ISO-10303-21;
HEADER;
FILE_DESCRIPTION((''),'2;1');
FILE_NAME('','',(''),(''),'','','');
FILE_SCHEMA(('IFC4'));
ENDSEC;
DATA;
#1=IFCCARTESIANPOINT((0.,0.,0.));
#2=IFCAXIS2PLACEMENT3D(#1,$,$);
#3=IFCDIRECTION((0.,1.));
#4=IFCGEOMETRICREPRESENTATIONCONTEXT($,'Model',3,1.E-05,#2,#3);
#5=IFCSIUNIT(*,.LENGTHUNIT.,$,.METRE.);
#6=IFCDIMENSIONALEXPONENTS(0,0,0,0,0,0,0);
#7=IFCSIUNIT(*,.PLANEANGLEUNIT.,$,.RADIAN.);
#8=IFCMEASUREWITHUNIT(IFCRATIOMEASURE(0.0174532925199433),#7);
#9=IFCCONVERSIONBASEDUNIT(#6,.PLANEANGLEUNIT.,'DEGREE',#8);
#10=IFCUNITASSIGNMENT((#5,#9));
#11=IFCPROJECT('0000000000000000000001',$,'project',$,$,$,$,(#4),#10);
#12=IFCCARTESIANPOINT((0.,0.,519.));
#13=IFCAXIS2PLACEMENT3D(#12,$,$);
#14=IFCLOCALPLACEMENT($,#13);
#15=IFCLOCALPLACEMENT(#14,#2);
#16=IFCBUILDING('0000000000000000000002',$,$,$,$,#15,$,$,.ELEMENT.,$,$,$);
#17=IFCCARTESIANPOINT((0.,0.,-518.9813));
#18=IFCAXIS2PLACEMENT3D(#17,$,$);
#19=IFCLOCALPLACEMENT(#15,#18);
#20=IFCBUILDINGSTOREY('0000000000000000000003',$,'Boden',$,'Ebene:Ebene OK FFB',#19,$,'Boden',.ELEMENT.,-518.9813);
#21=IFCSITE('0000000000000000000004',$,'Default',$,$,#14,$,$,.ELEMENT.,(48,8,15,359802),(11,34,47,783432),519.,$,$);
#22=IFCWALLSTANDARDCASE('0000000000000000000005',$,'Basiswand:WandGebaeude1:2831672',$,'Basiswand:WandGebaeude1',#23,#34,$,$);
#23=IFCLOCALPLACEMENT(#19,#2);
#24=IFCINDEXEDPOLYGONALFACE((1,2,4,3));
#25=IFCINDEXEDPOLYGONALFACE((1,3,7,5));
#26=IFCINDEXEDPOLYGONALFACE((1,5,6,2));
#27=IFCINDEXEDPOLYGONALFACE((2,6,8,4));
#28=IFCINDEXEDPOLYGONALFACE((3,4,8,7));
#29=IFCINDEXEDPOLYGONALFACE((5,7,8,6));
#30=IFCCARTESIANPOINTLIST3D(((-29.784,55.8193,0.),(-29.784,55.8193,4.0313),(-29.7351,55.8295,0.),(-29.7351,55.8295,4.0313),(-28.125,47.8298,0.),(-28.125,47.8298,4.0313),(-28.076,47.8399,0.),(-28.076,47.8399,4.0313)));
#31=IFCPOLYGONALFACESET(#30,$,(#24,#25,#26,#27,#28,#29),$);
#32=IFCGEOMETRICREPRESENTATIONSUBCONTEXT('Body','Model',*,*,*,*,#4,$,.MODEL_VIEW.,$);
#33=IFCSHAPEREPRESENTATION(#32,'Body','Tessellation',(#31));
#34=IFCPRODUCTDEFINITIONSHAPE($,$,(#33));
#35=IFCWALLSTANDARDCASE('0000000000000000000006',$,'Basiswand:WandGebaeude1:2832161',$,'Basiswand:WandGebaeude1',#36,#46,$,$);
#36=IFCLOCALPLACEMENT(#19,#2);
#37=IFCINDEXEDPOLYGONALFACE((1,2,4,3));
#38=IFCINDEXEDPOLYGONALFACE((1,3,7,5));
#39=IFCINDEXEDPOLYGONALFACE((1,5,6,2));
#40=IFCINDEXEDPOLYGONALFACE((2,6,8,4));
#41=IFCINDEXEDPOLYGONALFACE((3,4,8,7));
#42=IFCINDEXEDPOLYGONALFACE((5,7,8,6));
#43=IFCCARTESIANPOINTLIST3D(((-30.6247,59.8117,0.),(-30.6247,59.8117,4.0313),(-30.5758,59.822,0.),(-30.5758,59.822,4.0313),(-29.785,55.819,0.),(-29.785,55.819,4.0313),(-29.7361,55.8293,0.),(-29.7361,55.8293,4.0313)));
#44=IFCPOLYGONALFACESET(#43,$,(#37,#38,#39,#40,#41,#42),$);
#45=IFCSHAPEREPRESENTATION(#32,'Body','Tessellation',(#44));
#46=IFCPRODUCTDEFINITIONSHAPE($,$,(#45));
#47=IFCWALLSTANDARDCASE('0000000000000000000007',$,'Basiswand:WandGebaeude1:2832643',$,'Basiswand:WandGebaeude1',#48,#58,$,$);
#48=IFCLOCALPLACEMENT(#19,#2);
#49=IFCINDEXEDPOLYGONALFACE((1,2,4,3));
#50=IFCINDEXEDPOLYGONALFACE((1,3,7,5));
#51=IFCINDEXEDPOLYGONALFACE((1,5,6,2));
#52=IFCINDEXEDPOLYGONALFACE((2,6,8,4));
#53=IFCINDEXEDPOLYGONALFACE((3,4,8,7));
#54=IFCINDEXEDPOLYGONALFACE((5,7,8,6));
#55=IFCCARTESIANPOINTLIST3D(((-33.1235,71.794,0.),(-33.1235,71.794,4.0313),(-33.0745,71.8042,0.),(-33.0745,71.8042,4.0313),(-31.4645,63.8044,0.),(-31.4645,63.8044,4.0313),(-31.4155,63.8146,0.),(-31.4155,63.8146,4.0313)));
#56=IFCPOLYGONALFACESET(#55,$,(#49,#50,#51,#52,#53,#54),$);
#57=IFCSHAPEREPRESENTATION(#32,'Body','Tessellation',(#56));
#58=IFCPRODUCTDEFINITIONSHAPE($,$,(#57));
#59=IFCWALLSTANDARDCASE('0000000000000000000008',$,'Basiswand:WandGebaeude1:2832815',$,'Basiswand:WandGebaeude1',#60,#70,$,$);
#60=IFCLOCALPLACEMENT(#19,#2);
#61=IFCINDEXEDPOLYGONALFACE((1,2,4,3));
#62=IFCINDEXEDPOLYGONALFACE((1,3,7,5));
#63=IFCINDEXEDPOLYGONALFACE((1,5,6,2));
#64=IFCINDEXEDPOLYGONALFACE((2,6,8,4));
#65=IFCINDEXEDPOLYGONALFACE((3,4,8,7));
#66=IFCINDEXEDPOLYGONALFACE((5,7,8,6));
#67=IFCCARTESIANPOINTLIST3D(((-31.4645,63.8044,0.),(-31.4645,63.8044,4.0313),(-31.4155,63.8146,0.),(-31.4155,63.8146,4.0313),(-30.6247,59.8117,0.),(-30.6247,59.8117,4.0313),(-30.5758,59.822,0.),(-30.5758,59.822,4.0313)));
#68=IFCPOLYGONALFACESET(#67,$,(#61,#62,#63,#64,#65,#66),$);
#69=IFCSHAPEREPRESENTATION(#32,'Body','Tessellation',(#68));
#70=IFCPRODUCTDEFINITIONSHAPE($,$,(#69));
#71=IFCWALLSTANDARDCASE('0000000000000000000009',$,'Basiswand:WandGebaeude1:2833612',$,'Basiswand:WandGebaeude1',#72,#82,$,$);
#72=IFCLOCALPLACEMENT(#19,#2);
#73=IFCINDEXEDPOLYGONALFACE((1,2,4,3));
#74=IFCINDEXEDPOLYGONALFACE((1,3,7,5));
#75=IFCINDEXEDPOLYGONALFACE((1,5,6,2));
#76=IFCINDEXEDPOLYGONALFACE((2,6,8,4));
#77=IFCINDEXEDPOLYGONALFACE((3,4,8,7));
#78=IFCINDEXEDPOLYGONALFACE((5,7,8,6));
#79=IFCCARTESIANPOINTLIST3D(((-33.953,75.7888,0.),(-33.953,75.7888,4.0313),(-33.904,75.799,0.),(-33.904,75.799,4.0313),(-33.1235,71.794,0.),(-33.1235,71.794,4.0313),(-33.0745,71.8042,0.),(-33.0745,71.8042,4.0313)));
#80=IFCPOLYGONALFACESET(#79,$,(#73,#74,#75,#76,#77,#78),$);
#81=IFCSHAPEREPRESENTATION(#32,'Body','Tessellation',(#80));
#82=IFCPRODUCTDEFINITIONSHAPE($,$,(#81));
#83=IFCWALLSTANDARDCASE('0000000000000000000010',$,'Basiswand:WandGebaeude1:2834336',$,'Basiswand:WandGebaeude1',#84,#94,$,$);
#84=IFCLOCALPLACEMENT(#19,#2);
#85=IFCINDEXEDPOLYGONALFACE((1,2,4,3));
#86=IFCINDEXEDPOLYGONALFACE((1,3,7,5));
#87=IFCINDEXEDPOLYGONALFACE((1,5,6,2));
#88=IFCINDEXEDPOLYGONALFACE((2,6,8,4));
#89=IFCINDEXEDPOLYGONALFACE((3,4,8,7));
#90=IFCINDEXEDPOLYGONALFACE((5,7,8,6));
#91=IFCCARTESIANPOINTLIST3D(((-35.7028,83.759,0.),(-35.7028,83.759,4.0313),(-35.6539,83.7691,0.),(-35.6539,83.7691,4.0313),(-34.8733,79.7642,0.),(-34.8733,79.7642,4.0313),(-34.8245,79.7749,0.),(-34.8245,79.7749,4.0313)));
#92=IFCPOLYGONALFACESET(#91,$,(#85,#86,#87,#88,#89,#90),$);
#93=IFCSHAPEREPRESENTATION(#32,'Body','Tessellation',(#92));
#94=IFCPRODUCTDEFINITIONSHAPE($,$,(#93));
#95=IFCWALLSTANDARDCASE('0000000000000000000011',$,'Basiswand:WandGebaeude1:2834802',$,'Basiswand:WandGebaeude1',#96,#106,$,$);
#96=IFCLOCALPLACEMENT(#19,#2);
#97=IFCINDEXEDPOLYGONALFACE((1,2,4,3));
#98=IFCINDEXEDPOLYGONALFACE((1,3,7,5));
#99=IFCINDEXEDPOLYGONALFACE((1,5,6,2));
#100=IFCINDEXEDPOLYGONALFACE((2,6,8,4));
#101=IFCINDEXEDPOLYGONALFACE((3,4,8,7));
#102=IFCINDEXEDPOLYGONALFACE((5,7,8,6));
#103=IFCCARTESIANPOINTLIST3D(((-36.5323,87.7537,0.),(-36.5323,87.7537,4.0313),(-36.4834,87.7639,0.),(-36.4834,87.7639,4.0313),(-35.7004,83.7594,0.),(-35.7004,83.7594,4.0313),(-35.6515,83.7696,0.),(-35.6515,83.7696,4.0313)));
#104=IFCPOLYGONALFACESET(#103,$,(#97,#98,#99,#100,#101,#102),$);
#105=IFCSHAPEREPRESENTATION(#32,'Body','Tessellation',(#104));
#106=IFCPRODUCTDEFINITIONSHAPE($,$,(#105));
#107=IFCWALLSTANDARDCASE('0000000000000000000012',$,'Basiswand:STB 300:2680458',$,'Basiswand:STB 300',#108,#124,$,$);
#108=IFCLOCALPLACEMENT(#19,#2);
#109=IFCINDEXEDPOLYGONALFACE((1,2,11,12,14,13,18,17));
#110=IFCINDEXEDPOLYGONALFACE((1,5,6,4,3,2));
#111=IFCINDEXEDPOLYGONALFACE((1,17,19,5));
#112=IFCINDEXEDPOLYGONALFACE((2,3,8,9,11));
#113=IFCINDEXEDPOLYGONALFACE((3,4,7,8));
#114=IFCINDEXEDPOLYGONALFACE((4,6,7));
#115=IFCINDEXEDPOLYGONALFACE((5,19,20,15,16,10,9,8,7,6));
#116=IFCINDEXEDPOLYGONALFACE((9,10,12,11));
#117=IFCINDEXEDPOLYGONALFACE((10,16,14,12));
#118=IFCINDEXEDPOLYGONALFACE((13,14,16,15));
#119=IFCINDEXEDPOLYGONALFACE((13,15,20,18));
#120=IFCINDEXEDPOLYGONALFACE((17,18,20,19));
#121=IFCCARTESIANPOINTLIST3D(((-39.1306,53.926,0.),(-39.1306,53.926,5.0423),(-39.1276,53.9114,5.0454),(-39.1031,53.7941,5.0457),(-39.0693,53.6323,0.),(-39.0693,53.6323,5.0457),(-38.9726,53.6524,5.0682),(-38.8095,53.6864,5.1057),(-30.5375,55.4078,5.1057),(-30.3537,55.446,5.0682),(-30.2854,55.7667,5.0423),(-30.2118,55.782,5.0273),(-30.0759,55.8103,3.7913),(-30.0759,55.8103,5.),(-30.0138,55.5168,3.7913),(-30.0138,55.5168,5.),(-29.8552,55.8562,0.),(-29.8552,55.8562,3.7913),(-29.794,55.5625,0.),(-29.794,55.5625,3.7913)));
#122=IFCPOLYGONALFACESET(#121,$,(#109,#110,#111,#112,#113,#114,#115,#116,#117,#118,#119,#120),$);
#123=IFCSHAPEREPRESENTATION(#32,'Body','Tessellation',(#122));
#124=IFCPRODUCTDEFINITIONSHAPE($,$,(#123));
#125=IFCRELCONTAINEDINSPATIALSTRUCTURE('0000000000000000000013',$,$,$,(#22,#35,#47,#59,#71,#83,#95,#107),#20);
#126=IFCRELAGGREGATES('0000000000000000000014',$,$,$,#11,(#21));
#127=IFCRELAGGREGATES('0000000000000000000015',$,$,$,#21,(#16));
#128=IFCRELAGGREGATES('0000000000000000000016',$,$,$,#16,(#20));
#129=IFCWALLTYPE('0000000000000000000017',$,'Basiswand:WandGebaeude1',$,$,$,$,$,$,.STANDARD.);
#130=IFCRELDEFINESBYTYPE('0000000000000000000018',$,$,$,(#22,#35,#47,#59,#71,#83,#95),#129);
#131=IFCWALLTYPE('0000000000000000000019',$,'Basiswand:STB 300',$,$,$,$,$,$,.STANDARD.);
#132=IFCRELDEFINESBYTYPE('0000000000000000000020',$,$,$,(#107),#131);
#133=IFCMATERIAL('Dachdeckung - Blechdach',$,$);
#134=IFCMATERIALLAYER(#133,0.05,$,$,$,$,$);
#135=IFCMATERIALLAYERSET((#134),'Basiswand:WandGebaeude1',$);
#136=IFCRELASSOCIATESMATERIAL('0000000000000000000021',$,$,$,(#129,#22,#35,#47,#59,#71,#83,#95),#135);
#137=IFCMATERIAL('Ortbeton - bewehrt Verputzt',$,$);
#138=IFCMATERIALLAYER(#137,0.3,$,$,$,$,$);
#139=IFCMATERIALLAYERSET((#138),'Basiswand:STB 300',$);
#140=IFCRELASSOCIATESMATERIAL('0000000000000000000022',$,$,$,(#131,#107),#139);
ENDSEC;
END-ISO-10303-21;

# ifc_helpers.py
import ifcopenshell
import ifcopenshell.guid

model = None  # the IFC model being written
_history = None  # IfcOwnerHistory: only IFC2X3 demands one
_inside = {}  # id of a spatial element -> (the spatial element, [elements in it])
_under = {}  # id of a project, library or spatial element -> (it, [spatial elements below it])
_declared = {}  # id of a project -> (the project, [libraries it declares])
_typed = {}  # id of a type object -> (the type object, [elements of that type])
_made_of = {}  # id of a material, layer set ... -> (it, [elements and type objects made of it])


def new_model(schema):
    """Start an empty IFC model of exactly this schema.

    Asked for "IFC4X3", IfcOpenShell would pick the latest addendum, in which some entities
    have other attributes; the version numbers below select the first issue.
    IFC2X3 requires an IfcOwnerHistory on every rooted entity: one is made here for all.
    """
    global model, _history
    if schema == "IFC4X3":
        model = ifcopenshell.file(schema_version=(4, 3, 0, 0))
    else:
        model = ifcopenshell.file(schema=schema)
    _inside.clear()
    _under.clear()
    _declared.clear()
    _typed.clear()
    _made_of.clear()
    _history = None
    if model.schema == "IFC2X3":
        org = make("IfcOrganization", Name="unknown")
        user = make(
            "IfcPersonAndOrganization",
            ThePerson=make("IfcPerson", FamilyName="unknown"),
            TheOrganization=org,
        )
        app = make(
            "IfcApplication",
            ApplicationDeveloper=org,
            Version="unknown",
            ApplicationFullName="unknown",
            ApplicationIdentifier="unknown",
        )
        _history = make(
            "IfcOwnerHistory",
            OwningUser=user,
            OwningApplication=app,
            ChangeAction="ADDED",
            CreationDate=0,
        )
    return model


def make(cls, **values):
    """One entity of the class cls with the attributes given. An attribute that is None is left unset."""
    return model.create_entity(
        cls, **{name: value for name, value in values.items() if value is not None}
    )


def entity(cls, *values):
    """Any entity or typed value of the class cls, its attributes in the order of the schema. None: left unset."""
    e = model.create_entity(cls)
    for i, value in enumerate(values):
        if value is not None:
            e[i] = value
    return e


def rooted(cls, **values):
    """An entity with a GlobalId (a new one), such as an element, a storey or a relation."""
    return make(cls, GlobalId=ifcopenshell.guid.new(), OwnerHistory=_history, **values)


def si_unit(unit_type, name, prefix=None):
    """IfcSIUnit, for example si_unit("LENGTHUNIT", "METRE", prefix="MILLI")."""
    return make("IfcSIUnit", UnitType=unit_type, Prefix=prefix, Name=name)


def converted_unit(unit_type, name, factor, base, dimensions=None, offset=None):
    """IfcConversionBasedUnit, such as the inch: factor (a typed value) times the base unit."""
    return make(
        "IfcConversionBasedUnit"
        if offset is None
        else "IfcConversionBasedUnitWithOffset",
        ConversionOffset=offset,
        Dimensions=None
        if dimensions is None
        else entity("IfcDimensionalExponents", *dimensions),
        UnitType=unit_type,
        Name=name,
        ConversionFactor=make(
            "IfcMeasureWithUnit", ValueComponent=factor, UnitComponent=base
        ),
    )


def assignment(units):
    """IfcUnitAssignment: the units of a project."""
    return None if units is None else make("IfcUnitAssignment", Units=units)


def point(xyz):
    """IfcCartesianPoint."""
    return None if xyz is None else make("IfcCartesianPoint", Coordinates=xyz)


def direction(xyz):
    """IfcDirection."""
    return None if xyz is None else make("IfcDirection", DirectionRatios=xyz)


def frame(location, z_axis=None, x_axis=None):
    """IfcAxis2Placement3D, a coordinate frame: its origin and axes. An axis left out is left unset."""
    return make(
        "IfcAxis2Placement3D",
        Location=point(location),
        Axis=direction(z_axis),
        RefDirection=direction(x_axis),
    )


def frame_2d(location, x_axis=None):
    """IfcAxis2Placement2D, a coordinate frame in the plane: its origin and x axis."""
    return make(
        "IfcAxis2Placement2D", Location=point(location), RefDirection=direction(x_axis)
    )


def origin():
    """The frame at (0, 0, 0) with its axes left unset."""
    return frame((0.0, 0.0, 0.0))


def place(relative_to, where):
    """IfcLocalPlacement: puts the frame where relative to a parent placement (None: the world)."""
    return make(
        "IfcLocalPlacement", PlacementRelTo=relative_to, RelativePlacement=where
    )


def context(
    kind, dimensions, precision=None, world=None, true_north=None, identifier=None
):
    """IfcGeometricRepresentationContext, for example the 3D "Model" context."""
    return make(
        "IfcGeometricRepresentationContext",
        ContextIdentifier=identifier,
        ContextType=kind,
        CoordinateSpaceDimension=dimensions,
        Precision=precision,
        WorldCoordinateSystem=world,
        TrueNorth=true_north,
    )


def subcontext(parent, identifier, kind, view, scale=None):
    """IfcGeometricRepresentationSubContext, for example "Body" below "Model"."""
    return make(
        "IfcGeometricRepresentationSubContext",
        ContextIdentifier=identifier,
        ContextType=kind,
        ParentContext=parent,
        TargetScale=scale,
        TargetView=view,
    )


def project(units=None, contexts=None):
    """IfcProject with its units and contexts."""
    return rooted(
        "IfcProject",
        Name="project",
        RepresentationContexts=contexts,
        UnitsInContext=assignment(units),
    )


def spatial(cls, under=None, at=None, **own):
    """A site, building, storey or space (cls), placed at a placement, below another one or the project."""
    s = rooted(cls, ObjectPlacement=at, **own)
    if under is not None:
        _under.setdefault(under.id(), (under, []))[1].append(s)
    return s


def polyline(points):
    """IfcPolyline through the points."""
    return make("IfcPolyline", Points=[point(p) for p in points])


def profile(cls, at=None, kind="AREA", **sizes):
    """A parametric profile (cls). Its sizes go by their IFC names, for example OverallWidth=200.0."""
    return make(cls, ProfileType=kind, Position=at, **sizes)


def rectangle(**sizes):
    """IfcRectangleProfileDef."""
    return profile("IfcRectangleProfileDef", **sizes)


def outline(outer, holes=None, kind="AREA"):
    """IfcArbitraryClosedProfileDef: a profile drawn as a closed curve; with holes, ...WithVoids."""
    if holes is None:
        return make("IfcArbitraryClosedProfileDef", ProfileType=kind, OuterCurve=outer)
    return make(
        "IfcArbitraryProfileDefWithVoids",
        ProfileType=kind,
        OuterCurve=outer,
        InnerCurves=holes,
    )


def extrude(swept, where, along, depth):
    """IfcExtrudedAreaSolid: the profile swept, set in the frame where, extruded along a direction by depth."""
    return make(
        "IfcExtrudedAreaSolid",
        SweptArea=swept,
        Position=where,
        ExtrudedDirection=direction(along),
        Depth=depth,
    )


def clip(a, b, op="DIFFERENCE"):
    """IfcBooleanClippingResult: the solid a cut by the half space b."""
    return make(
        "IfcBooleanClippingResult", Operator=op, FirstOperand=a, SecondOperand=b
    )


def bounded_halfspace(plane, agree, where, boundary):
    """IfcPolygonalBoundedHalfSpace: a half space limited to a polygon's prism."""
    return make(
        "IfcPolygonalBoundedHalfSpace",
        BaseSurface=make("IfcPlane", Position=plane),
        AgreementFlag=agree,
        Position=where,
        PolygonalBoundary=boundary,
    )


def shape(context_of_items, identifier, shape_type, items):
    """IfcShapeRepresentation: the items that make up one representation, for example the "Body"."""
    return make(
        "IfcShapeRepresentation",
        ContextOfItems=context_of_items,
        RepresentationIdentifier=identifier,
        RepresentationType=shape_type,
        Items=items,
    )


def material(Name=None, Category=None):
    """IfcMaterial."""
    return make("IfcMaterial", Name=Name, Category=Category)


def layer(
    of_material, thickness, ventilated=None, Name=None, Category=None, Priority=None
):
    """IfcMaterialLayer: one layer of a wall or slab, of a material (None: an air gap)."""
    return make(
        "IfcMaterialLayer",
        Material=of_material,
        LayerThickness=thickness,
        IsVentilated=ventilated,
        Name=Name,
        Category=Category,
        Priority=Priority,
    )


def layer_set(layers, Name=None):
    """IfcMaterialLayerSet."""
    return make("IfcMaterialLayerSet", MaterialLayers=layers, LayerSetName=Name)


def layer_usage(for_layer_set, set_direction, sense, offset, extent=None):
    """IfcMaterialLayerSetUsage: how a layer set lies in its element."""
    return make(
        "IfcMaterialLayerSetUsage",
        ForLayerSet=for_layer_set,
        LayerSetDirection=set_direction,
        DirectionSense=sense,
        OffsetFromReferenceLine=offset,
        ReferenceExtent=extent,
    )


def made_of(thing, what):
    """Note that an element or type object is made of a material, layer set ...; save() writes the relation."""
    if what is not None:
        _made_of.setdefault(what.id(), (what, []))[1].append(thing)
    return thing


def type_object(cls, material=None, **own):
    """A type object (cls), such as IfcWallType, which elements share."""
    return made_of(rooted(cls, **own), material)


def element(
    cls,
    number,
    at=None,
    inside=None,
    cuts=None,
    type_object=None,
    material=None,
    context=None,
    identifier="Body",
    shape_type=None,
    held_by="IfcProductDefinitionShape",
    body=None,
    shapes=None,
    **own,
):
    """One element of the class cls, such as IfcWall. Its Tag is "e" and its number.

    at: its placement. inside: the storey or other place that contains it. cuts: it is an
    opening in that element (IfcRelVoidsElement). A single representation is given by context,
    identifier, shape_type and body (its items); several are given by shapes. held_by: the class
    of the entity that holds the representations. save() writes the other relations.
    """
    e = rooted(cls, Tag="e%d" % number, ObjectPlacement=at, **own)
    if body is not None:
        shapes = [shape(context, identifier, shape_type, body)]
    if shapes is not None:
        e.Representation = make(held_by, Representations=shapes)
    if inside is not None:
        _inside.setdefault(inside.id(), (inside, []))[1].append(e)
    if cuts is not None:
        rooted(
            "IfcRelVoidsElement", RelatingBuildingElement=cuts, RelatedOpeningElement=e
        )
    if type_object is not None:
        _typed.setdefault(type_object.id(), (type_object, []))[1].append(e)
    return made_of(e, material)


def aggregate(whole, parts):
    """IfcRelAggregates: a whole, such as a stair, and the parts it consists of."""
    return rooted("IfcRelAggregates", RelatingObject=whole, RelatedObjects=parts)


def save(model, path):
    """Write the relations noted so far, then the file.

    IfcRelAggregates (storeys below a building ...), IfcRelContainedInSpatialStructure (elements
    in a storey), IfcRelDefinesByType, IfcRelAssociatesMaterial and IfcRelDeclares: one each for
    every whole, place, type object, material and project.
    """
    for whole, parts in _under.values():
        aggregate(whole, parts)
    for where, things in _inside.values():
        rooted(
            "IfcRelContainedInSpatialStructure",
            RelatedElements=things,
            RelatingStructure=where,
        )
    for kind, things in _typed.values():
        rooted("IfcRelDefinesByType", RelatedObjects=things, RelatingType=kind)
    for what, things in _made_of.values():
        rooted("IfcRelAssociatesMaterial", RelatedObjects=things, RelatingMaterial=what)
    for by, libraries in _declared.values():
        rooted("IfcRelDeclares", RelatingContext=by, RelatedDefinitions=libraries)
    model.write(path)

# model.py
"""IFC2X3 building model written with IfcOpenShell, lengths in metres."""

from ifc_helpers import new_model, entity, si_unit, converted_unit, direction, frame, frame_2d, origin, place, context, subcontext, project, spatial, polyline, rectangle, outline, extrude, clip, bounded_halfspace, material, layer, layer_set, layer_usage, type_object, element, save


model = new_model("IFC2X3")

# Units and contexts
model_context = context("Model", 3, precision=1e-05, world=origin(), true_north=direction((0.0, 1.0)))
body_context = subcontext(model_context, "Body", "Model", "MODEL_VIEW")
ifc_project = project(units=[si_unit("LENGTHUNIT", "METRE"), converted_unit("PLANEANGLEUNIT", "DEGREE", entity("IfcRatioMeasure", 0.0174532925199433), si_unit("PLANEANGLEUNIT", "RADIAN"), dimensions=[0, 0, 0, 0, 0, 0, 0])], contexts=[model_context])

# Site, building, storey
site_placement = place(None, frame((0.0, 0.0, 519.0)))
site = spatial("IfcSite", under=ifc_project, at=site_placement, Name="Default", CompositionType="ELEMENT", RefLatitude=(48, 8, 15, 359802), RefLongitude=(11, 34, 47, 783432), RefElevation=519.0)
building_placement = place(site_placement, origin())
building = spatial("IfcBuilding", under=site, at=building_placement, CompositionType="ELEMENT")
storey_placement = place(building_placement, frame((0.0, 0.0, -518.9813)))
storey = spatial("IfcBuildingStorey", under=building, at=storey_placement, Name="Boden", ObjectType="Ebene:Ebene OK FFB", LongName="Boden", CompositionType="ELEMENT", Elevation=-518.9813)

# Walls
ifc_material_1 = material(Name="Dachdeckung - Blechdach")
ifc_layer_1 = layer(ifc_material_1, 0.05)
ifc_layer_set_1 = layer_set([ifc_layer_1], Name="Basiswand:WandGebaeude1")
wall_type_1 = type_object("IfcWallType", Name="Basiswand:WandGebaeude1", PredefinedType="STANDARD", material=ifc_layer_set_1)
ifc_layer_usage_1 = layer_usage(ifc_layer_set_1, "AXIS2", "NEGATIVE", 0.025)
wall_1_placement = place(storey_placement, frame((-28.1005, 47.8349, 0.0), z_axis=(0.0, 0.0, 1.0), x_axis=(-0.203311, 0.979114, 0.0)))
element("IfcWallStandardCase", 1, at=wall_1_placement, inside=storey, type_object=wall_type_1, material=ifc_layer_usage_1, Name="Basiswand:WandGebaeude1:2831672", ObjectType="Basiswand:WandGebaeude1", context=body_context, shape_type="SweptSolid", body=[
    extrude(rectangle(XDim=8.16, YDim=0.05, at=frame_2d((4.08, 0.0), x_axis=(-1.0, 0.0))), origin(), (0.0, 0.0, 1.0), 4.0313),
])
ifc_layer_usage_2 = layer_usage(ifc_layer_set_1, "AXIS2", "NEGATIVE", 0.025)
wall_2_placement = place(storey_placement, frame((-29.7606, 55.8241, 0.0), z_axis=(0.0, 0.0, 1.0), x_axis=(-0.20581, 0.978592, 0.0)))
element("IfcWallStandardCase", 2, at=wall_2_placement, inside=storey, type_object=wall_type_1, material=ifc_layer_usage_2, Name="Basiswand:WandGebaeude1:2832161", ObjectType="Basiswand:WandGebaeude1", context=body_context, shape_type="SweptSolid", body=[
    extrude(rectangle(XDim=4.08, YDim=0.05, at=frame_2d((2.04, 0.0), x_axis=(-1.0, 0.0))), origin(), (0.0, 0.0, 1.0), 4.0313),
])
ifc_layer_usage_3 = layer_usage(ifc_layer_set_1, "AXIS2", "NEGATIVE", 0.025)
wall_3_placement = place(storey_placement, frame((-31.44, 63.8095, 0.0), z_axis=(0.0, 0.0, 1.0), x_axis=(-0.203311, 0.979114, 0.0)))
element("IfcWallStandardCase", 3, at=wall_3_placement, inside=storey, type_object=wall_type_1, material=ifc_layer_usage_3, Name="Basiswand:WandGebaeude1:2832643", ObjectType="Basiswand:WandGebaeude1", context=body_context, shape_type="SweptSolid", body=[
    extrude(outline(polyline([(8.1601, -0.025), (8.1601, 0.025), (0.0, 0.025), (0.0001, -0.025), (8.1601, -0.025)])), origin(), (0.0, 0.0, 1.0), 4.0313),
])
ifc_layer_usage_4 = layer_usage(ifc_layer_set_1, "AXIS2", "NEGATIVE", 0.025)
wall_4_placement = place(storey_placement, frame((-30.6003, 59.8168, 0.0), z_axis=(0.0, 0.0, 1.0), x_axis=(-0.20581, 0.978592, 0.0)))
element("IfcWallStandardCase", 4, at=wall_4_placement, inside=storey, type_object=wall_type_1, material=ifc_layer_usage_4, Name="Basiswand:WandGebaeude1:2832815", ObjectType="Basiswand:WandGebaeude1", context=body_context, shape_type="SweptSolid", body=[
    extrude(outline(polyline([(4.08, -0.025), (4.0801, 0.025), (0.0, 0.025), (0.0, -0.025), (4.08, -0.025)])), origin(), (0.0, 0.0, 1.0), 4.0313),
])
ifc_layer_usage_5 = layer_usage(ifc_layer_set_1, "AXIS2", "NEGATIVE", 0.025)
wall_5_placement = place(storey_placement, frame((-33.099, 71.7991, 0.0), z_axis=(0.0, 0.0, 1.0), x_axis=(-0.203311, 0.979114, 0.0)))
element("IfcWallStandardCase", 5, at=wall_5_placement, inside=storey, type_object=wall_type_1, material=ifc_layer_usage_5, Name="Basiswand:WandGebaeude1:2833612", ObjectType="Basiswand:WandGebaeude1", context=body_context, shape_type="SweptSolid", body=[
    extrude(rectangle(XDim=4.08, YDim=0.05, at=frame_2d((2.04, 0.0), x_axis=(-1.0, 0.0))), origin(), (0.0, 0.0, 1.0), 4.0313),
])
ifc_layer_usage_6 = layer_usage(ifc_layer_set_1, "AXIS2", "NEGATIVE", 0.025)
wall_6_placement = place(storey_placement, frame((-34.8488, 79.7693, 0.0), z_axis=(0.0, 0.0, 1.0), x_axis=(-0.203311, 0.979114, 0.0)))
element("IfcWallStandardCase", 6, at=wall_6_placement, inside=storey, type_object=wall_type_1, material=ifc_layer_usage_6, Name="Basiswand:WandGebaeude1:2834336", ObjectType="Basiswand:WandGebaeude1", context=body_context, shape_type="SweptSolid", body=[
    extrude(outline(polyline([(4.08, -0.025), (4.08, 0.025), (0.0, 0.025), (0.0006, -0.025), (4.08, -0.025)])), origin(), (0.0, 0.0, 1.0), 4.0313),
])
ifc_layer_usage_7 = layer_usage(ifc_layer_set_1, "AXIS2", "NEGATIVE", 0.025)
wall_7_placement = place(storey_placement, frame((-35.6759, 83.7645, 0.0), z_axis=(0.0, 0.0, 1.0), x_axis=(-0.203899, 0.978992, 0.0)))
element("IfcWallStandardCase", 7, at=wall_7_placement, inside=storey, type_object=wall_type_1, material=ifc_layer_usage_7, Name="Basiswand:WandGebaeude1:2834802", ObjectType="Basiswand:WandGebaeude1", context=body_context, shape_type="SweptSolid", body=[
    extrude(rectangle(XDim=4.08, YDim=0.05, at=frame_2d((2.04, 0.0), x_axis=(-1.0, 0.0))), origin(), (0.0, 0.0, 1.0), 4.0313),
])
ifc_material_2 = material(Name="Ortbeton - bewehrt Verputzt")
ifc_layer_2 = layer(ifc_material_2, 0.3)
ifc_layer_set_2 = layer_set([ifc_layer_2], Name="Basiswand:STB 300")
ifc_layer_usage_8 = layer_usage(ifc_layer_set_2, "AXIS2", "NEGATIVE", 0.15)
wall_type_2 = type_object("IfcWallType", Name="Basiswand:STB 300", PredefinedType="STANDARD", material=ifc_layer_set_2)
wall_8_placement = place(storey_placement, frame((-39.1001, 53.7791, 0.0), z_axis=(0.0, 0.0, 1.0), x_axis=(0.979026, 0.203735, 0.0)))
element("IfcWallStandardCase", 8, at=wall_8_placement, inside=storey, type_object=wall_type_2, material=ifc_layer_usage_8, Name="Basiswand:STB 300:2680458", ObjectType="Basiswand:STB 300", context=body_context, shape_type="Clipping", body=[
    clip(clip(clip(clip(clip(clip(extrude(outline(polyline([(9.4742, -0.15), (9.4742, 0.15), (0.0, 0.15), (0.0002, -0.15), (9.4742, -0.15)])), origin(), (0.0, 0.0, 1.0), 5.1057), bounded_halfspace(frame((0.0002, -0.15, 5.0457), z_axis=(-0.222663, -0.00016, 0.974895), x_axis=(0.00072, -1.0, 0.0)), False, frame((0.0002, -0.15, 5.0457)), polyline([(0.0, 0.0), (0.0987, 0.0), (-0.0001, 0.1652), (0.0, 0.0)]))), bounded_halfspace(frame((0.0989, -0.15, 5.0682), z_axis=(-0.219592, 0.001771, 0.97559), x_axis=(0.509857, -0.85236, 0.116309)), False, frame((0.0989, -0.15, 5.0682)), polyline([(0.0, 0.0), (0.1667, 0.0), (-0.0989, 0.2851), (-0.0988, 0.1652), (0.0, 0.0)]))), bounded_halfspace(frame((0.2656, -0.15, 5.1057), z_axis=(0.0, 0.206908, 0.97836), x_axis=(0.673585, -0.723115, 0.152928)), False, frame((0.2656, -0.15, 5.1057)), polyline([(0.0, 0.0), (8.4491, 0.0), (8.7691, 0.3), (-0.2656, 0.3), (-0.2656, 0.2851), (0.0, 0.0)]))), bounded_halfspace(frame((8.9025, -0.15, 5.0682), z_axis=(0.192856, 0.000613, 0.981227), x_axis=(-0.003178, 0.999995, 0.0)), False, frame((8.9025, -0.15, 5.0682)), polyline([(0.0, 0.0), (0.3471, 0.0), (0.3462, 0.3), (0.2073, 0.3), (0.0, 0.0)]))), bounded_halfspace(frame((8.7147, -0.15, 5.1057), z_axis=(0.19591, -0.00158, 0.980621), x_axis=(-0.722017, -0.676903, 0.143155)), False, frame((8.7147, -0.15, 5.1057)), polyline([(0.0, 0.0), (0.1878, 0.0), (0.3951, 0.3), (0.32, 0.3), (0.0, 0.0)]))), bounded_halfspace(frame((9.2497, -0.15, 3.7913), z_axis=(0.0, 0.0, 1.0), x_axis=(0.0, 1.0, 0.0)), False, frame((9.2497, -0.15, 3.7913)), polyline([(0.0, 0.0), (0.2245, 0.0), (0.2245, 0.3), (-0.001, 0.3), (0.0, 0.0)]))),
])

save(model, "model.ifc")
